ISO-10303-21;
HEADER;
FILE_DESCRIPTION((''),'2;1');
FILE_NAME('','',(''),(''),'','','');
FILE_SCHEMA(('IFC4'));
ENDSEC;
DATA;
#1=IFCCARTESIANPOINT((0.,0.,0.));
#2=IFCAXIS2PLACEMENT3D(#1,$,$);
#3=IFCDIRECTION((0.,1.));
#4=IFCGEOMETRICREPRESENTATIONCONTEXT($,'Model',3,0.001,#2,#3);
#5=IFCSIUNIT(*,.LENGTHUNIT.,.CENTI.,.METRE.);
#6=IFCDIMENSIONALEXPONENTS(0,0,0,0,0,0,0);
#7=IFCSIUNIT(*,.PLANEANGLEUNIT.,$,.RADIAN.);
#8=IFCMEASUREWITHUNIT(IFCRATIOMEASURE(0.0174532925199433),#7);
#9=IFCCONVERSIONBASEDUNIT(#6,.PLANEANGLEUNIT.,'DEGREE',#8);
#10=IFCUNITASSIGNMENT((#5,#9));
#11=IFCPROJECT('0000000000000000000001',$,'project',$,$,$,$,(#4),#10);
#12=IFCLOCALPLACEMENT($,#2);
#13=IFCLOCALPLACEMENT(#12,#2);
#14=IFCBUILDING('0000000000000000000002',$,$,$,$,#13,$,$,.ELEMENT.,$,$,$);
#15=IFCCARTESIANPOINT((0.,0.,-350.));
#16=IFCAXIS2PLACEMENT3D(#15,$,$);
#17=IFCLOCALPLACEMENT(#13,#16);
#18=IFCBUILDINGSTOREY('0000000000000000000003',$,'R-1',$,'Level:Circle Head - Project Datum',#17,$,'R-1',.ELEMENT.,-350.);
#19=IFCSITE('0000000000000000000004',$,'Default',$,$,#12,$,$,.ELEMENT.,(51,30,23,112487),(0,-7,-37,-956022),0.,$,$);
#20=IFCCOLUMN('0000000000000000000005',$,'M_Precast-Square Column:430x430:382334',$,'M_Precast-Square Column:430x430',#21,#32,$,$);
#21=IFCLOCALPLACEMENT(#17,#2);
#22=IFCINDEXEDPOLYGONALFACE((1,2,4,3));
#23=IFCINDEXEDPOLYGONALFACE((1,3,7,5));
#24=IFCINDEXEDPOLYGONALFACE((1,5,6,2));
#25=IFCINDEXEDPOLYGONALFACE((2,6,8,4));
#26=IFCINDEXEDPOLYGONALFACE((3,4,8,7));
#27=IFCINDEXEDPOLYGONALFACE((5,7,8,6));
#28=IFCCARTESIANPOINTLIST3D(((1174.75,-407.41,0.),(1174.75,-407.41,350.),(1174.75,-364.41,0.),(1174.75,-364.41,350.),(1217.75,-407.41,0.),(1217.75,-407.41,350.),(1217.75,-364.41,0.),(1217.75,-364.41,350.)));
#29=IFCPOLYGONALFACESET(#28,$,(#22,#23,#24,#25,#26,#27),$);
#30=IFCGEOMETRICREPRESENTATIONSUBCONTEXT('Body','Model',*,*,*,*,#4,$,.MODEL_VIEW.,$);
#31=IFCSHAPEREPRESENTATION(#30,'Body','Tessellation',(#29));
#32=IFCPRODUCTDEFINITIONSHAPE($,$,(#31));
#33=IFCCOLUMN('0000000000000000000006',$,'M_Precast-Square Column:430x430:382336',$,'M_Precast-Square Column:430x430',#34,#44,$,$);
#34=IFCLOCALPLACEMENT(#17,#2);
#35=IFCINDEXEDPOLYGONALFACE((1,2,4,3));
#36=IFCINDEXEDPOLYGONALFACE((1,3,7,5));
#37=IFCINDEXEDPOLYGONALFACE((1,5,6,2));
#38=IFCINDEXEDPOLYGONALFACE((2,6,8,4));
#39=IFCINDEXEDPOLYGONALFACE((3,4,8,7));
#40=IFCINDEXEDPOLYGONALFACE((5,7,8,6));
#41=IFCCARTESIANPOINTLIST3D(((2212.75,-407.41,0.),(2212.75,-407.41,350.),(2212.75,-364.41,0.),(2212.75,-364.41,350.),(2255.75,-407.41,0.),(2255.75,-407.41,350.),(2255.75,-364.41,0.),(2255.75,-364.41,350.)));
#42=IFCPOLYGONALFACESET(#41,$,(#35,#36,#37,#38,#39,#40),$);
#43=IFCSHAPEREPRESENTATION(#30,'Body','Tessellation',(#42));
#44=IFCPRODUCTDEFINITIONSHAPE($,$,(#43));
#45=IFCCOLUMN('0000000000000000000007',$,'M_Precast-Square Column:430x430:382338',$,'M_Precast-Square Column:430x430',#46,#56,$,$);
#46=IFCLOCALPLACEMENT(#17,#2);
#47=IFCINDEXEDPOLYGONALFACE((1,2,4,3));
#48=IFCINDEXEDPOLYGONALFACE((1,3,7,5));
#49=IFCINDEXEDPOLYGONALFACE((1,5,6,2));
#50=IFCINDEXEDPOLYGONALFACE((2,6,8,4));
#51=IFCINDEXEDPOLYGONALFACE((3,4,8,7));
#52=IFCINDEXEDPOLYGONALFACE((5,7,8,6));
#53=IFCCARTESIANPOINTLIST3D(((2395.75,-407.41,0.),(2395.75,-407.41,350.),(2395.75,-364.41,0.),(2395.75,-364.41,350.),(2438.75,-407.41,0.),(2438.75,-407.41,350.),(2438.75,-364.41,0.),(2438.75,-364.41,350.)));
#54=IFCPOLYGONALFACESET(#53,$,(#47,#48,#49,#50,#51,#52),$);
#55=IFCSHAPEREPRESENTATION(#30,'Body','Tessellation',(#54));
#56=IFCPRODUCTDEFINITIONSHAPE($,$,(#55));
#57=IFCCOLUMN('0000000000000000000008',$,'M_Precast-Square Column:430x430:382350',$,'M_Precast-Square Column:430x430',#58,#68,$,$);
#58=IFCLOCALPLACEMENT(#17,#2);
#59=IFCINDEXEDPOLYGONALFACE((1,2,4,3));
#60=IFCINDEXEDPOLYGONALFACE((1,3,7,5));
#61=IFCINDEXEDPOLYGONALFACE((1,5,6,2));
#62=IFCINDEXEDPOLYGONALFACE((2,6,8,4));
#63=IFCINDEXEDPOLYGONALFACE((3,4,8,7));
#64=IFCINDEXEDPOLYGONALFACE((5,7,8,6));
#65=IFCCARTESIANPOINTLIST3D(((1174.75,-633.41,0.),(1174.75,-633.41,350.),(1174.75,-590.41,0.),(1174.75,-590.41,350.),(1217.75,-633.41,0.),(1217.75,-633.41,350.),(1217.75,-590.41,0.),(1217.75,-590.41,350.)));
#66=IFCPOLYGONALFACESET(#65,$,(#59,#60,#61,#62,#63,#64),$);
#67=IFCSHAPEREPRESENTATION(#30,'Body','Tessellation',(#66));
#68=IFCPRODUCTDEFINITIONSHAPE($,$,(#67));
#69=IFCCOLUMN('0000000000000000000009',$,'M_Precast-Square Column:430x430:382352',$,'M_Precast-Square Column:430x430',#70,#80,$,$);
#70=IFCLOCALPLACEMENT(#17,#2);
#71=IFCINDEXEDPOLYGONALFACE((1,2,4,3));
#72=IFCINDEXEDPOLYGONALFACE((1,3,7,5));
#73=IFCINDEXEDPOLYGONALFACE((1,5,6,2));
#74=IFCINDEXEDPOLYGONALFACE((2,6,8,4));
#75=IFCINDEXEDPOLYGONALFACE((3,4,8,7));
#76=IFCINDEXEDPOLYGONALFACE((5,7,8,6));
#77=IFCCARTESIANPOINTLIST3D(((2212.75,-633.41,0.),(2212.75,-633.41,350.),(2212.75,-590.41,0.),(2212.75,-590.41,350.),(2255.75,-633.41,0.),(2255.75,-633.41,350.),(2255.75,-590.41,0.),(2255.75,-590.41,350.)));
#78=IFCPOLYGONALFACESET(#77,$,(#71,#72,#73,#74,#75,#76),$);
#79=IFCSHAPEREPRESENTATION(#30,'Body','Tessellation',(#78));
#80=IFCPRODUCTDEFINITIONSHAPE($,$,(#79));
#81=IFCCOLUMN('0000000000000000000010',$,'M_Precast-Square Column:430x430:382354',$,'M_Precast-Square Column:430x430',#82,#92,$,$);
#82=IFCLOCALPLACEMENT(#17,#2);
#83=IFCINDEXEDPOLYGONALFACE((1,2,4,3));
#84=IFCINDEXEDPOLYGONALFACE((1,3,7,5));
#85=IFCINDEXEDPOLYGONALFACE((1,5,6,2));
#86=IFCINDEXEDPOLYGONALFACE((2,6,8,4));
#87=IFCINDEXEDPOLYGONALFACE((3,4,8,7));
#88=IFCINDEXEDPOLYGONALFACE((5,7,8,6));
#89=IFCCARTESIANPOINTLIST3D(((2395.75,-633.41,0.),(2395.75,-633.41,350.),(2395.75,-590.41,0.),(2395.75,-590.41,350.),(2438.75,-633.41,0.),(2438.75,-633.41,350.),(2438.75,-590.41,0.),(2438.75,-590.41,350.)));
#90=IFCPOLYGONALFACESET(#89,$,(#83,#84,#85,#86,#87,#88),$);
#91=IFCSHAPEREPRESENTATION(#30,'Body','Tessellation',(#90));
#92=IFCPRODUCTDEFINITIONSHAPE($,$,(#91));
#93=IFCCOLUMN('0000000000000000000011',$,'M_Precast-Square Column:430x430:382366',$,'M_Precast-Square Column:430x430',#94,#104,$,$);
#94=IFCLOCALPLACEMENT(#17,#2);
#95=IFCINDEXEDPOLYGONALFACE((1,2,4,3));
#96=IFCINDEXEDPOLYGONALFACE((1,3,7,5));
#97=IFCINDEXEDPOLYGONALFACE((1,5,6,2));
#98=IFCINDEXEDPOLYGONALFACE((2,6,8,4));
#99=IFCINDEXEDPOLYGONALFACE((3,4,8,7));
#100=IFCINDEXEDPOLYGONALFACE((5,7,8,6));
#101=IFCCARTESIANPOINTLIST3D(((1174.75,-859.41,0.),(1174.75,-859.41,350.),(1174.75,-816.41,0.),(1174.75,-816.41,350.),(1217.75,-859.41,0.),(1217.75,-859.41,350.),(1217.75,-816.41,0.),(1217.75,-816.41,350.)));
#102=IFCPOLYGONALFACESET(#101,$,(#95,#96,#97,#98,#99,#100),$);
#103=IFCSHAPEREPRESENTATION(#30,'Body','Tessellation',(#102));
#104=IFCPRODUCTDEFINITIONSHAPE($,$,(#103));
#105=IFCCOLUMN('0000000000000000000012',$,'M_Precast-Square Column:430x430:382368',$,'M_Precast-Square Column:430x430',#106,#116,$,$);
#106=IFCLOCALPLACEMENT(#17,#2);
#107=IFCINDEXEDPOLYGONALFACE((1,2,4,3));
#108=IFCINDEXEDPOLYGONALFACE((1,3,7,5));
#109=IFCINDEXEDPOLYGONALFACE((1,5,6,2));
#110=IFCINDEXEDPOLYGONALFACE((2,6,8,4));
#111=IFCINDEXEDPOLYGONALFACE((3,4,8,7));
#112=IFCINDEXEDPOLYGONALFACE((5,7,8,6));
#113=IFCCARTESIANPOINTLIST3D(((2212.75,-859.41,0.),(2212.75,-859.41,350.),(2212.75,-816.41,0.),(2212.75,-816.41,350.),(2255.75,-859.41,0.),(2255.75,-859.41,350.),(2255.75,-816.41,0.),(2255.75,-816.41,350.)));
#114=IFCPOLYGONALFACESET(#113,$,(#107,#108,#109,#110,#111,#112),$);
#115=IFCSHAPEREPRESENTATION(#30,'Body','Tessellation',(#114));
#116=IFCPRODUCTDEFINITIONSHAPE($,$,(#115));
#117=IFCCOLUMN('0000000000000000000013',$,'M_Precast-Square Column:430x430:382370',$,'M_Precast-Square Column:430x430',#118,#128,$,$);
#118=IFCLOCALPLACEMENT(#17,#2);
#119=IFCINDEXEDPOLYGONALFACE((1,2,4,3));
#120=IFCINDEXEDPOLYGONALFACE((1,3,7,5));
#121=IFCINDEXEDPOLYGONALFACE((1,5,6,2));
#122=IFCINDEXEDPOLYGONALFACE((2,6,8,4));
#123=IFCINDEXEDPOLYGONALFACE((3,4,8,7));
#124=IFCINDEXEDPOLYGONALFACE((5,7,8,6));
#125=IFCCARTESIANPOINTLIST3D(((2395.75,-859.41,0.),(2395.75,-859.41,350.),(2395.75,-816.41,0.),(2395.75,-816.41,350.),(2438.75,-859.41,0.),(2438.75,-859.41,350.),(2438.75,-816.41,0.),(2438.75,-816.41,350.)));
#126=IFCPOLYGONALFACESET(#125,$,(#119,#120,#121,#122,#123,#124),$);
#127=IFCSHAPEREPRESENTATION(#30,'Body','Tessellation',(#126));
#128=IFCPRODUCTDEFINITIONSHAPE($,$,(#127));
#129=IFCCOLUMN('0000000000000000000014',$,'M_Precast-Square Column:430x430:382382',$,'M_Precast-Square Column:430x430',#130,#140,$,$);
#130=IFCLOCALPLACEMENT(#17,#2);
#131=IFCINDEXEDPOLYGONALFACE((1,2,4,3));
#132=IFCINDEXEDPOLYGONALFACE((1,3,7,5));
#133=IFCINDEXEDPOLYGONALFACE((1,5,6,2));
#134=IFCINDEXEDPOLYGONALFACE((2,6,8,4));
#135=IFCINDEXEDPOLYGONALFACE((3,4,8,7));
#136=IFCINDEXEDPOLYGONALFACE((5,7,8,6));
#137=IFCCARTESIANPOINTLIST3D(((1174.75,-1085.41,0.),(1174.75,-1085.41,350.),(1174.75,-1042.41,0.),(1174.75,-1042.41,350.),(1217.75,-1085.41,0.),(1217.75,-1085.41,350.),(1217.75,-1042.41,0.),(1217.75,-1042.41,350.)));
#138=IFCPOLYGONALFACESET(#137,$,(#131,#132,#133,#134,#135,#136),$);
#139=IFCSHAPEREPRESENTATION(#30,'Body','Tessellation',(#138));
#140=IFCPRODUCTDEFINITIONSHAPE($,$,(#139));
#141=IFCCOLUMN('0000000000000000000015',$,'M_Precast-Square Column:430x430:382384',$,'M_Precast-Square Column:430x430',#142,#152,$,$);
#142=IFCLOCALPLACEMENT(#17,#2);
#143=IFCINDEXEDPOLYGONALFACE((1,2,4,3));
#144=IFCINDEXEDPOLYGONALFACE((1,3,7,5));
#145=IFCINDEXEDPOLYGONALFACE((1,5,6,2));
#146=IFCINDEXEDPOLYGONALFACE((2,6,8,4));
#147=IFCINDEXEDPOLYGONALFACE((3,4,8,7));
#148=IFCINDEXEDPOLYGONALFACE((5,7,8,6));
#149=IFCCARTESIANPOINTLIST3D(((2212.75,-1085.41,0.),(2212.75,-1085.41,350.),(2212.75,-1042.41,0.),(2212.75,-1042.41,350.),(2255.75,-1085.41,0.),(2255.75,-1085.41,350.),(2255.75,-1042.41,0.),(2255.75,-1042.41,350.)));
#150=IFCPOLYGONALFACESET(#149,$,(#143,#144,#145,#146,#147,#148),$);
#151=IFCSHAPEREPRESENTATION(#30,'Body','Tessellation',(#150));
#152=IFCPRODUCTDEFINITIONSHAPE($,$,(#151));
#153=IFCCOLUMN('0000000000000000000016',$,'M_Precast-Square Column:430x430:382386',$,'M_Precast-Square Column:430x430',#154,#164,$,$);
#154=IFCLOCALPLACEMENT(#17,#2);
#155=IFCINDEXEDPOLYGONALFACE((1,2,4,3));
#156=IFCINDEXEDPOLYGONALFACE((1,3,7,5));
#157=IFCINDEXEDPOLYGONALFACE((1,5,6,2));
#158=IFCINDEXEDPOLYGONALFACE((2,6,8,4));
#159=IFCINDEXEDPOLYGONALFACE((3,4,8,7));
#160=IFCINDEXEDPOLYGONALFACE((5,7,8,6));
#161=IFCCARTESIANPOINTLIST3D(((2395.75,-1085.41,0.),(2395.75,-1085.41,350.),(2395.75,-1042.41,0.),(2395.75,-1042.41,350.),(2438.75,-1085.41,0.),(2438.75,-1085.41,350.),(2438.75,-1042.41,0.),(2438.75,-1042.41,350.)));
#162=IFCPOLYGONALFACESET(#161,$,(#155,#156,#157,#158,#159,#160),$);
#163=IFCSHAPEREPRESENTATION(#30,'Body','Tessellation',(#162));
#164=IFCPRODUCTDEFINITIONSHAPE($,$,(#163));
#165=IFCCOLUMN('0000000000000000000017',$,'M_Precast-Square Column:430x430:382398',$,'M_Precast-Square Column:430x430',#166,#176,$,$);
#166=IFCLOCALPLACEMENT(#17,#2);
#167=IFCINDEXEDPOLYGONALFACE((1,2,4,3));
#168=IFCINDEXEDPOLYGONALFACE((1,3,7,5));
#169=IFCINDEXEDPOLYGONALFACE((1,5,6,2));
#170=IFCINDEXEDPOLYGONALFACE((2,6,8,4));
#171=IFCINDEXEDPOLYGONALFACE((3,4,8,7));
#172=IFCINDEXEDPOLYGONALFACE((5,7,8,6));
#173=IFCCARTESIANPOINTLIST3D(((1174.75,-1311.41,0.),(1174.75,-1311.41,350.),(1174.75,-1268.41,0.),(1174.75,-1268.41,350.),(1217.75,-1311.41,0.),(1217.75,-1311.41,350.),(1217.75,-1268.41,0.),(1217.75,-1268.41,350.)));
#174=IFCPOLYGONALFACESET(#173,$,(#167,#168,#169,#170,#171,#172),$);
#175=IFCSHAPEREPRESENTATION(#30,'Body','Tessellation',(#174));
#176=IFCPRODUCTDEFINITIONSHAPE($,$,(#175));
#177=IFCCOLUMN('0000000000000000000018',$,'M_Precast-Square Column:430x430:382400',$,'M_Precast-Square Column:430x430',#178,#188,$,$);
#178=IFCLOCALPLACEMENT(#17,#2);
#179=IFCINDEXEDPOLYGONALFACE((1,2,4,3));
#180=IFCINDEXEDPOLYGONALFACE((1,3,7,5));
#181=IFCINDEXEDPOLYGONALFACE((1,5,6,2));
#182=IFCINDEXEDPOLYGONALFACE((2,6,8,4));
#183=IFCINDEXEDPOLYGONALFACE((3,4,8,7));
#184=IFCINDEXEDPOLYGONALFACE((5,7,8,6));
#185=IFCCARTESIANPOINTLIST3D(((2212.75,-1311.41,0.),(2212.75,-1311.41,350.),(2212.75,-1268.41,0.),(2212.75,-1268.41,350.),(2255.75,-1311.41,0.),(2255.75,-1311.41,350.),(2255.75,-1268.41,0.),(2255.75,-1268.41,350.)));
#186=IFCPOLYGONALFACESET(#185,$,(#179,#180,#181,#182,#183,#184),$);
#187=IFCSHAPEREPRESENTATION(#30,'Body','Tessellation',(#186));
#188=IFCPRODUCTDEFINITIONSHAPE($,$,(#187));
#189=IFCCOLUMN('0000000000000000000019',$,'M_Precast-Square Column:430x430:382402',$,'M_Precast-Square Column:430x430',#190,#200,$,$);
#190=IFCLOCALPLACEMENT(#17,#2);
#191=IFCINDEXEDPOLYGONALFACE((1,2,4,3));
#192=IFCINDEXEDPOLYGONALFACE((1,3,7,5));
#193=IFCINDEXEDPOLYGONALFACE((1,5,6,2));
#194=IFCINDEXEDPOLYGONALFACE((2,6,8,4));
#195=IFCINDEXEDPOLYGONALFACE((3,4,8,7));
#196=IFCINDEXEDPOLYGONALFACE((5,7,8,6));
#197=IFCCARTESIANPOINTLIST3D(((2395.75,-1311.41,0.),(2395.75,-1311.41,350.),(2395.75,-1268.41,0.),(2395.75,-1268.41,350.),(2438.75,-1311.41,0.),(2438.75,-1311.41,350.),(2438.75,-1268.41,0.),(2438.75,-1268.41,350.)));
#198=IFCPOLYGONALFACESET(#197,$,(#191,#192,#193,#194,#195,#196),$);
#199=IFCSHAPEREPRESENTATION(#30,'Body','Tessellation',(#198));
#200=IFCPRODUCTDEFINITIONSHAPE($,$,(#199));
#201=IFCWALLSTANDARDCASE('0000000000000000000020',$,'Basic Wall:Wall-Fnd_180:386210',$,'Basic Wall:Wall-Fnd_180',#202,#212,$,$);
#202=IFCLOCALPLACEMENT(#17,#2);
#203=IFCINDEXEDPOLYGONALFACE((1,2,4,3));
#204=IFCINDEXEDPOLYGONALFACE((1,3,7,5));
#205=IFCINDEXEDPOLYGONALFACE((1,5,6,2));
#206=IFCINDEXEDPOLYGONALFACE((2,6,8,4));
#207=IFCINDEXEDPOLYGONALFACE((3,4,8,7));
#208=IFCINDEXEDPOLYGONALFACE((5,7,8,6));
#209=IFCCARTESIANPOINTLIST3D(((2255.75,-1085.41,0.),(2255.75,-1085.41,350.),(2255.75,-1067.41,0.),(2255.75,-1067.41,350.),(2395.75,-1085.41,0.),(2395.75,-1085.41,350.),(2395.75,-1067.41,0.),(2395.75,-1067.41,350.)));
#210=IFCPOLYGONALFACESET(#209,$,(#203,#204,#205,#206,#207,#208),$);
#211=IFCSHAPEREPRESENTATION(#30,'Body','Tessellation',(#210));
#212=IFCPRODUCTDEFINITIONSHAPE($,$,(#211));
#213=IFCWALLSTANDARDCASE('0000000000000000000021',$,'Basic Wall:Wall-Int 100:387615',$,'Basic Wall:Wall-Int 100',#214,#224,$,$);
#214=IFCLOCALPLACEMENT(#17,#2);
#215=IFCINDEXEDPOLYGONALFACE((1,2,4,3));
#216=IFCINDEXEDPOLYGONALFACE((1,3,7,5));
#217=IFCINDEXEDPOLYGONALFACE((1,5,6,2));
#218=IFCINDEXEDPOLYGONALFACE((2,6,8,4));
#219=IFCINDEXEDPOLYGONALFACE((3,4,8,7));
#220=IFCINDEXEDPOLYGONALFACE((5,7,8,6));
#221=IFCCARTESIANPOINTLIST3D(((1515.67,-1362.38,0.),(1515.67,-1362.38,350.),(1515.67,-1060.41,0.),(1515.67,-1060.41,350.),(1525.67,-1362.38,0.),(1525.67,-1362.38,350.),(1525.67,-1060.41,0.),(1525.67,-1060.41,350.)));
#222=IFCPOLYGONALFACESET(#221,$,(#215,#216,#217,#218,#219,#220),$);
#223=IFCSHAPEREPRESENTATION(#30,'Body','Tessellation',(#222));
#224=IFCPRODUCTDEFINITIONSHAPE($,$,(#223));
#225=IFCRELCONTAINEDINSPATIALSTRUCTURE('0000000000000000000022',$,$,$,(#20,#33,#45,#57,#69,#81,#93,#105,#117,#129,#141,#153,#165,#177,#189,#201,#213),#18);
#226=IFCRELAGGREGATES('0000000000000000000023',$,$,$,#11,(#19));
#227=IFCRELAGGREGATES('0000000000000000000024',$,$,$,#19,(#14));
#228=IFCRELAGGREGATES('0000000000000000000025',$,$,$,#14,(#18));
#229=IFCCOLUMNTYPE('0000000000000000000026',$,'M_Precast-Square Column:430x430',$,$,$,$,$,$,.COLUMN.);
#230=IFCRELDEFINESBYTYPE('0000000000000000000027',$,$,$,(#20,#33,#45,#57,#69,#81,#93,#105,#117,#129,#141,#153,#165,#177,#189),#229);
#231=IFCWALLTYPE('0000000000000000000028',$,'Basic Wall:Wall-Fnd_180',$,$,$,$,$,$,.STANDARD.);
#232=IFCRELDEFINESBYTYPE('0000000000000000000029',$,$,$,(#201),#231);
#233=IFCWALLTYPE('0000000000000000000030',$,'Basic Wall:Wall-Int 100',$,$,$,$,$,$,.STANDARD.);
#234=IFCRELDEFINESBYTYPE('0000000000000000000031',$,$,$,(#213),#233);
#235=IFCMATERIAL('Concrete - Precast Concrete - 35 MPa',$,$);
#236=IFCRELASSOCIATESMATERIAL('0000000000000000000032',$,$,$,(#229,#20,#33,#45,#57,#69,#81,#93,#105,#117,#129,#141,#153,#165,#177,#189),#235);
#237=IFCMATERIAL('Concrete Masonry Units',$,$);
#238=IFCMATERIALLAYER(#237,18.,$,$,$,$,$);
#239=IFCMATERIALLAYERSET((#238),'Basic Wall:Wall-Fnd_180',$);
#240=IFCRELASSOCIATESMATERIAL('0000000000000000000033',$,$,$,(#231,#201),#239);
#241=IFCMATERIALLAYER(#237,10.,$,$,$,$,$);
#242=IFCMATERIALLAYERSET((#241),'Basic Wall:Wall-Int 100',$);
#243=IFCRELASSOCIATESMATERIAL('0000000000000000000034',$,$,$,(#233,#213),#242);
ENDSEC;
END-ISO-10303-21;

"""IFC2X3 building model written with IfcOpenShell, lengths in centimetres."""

from ifc_helpers import new_model, entity, si_unit, converted_unit, direction, frame, frame_2d, origin, origin_2d_with_axis, place, context, subcontext, project, spatial, rectangle, extrude, source, transform, mapped, material, layer, layer_set, layer_usage, type_object, type_shapes, element, save


model = new_model("IFC2X3")

# Units and contexts
model_context = context("Model", 3, precision=0.001, world=origin(), true_north=direction((0.0, 1.0)))
body_context = subcontext(model_context, "Body", "Model", "MODEL_VIEW")
ifc_project = project(units=[si_unit("LENGTHUNIT", "METRE", prefix="CENTI"), converted_unit("PLANEANGLEUNIT", "DEGREE", entity("IfcRatioMeasure", 0.0174532925199433), si_unit("PLANEANGLEUNIT", "RADIAN"), dimensions=[0, 0, 0, 0, 0, 0, 0])], contexts=[model_context])

# Site, building, storey
site_placement = place(None, origin())
site = spatial("IfcSite", under=ifc_project, at=site_placement, Name="Default", CompositionType="ELEMENT", RefLatitude=(51, 30, 23, 112487), RefLongitude=(0, -7, -37, -956022), RefElevation=0.0)
building_placement = place(site_placement, origin())
building = spatial("IfcBuilding", under=site, at=building_placement, CompositionType="ELEMENT")
storey_placement = place(building_placement, frame((0.0, 0.0, -350.0)))
storey = spatial("IfcBuildingStorey", under=building, at=storey_placement, Name="R-1", ObjectType="Level:Circle Head - Project Datum", LongName="R-1", CompositionType="ELEMENT", Elevation=-350.0)

# Columns
ifc_material_1 = material(Name="Concrete - Precast Concrete - 35 MPa")
column_type = type_object("IfcColumnType", Name="M_Precast-Square Column:430x430", PredefinedType="COLUMN", material=ifc_material_1)
shared_shape = source(origin(), body_context, "Body", "SweptSolid", [
    extrude(rectangle(XDim=43.0, YDim=43.0, at=origin_2d_with_axis()), frame((0.0, 0.0, -350.0), z_axis=(0.0, 0.0, 1.0), x_axis=(0.0, -1.0, 0.0)), (0.0, 0.0, 1.0), 350.0),
])
type_shapes(column_type, [shared_shape])
for number, where, z_axis, x_axis, name in (
    (1, (1196.25, -385.91, 350.0), (0.0, 0.0, 1.0), (-1.0, 0.0, 0.0), "M_Precast-Square Column:430x430:382334"),
    (2, (2234.25, -385.91, 350.0), (0.0, 0.0, 1.0), (-1.0, 0.0, 0.0), "M_Precast-Square Column:430x430:382336"),
    (3, (2417.25, -385.91, 350.0), (0.0, 0.0, 1.0), (-1.0, 0.0, 0.0), "M_Precast-Square Column:430x430:382338"),
    (4, (1196.25, -611.91, 350.0), (0.0, 0.0, 1.0), (-1.0, 0.0, 0.0), "M_Precast-Square Column:430x430:382350"),
    (5, (2234.25, -611.91, 350.0), (0.0, 0.0, 1.0), (-1.0, 0.0, 0.0), "M_Precast-Square Column:430x430:382352"),
    (6, (2417.25, -611.91, 350.0), (0.0, 0.0, 1.0), (-1.0, 0.0, 0.0), "M_Precast-Square Column:430x430:382354"),
    (7, (1196.25, -837.91, 350.0), (0.0, 0.0, 1.0), (-1.0, 0.0, 0.0), "M_Precast-Square Column:430x430:382366"),
    (8, (2234.25, -837.91, 350.0), (0.0, 0.0, 1.0), (-1.0, 0.0, 0.0), "M_Precast-Square Column:430x430:382368"),
    (9, (2417.25, -837.91, 350.0), (0.0, 0.0, 1.0), (-1.0, 0.0, 0.0), "M_Precast-Square Column:430x430:382370"),
    (10, (1196.25, -1063.91, 350.0), (0.0, 0.0, 1.0), (-1.0, 0.0, 0.0), "M_Precast-Square Column:430x430:382382"),
    (11, (2234.25, -1063.91, 350.0), (0.0, 0.0, 1.0), (-1.0, 0.0, 0.0), "M_Precast-Square Column:430x430:382384"),
    (12, (2417.25, -1063.91, 350.0), (0.0, 0.0, 1.0), (-1.0, 0.0, 0.0), "M_Precast-Square Column:430x430:382386"),
    (13, (1196.25, -1289.91, 350.0), (0.0, 0.0, 1.0), (-1.0, 0.0, 0.0), "M_Precast-Square Column:430x430:382398"),
    (14, (2234.25, -1289.91, 350.0), (0.0, 0.0, 1.0), (-1.0, 0.0, 0.0), "M_Precast-Square Column:430x430:382400"),
    (15, (2417.25, -1289.91, 350.0), (0.0, 0.0, 1.0), (-1.0, 0.0, 0.0), "M_Precast-Square Column:430x430:382402"),
):
    element("IfcColumn", number, at=place(storey_placement, frame(where, z_axis=z_axis, x_axis=x_axis)), inside=storey, type_object=column_type, material=ifc_material_1, Name=name, ObjectType="M_Precast-Square Column:430x430", context=body_context, shape_type="MappedRepresentation", body=[
        mapped(shared_shape, transform((0.0, 0.0, 0.0), scale=1.0)),
    ])

# Walls
ifc_material_2 = material(Name="Concrete Masonry Units")
ifc_layer_1 = layer(ifc_material_2, 18.0)
ifc_layer_set_1 = layer_set([ifc_layer_1], Name="Basic Wall:Wall-Fnd_180")
ifc_layer_usage_1 = layer_usage(ifc_layer_set_1, "AXIS2", "POSITIVE", -9.0)
wall_type_1 = type_object("IfcWallType", Name="Basic Wall:Wall-Fnd_180", PredefinedType="STANDARD", material=ifc_layer_set_1)
wall_1_placement = place(storey_placement, frame((2255.75, -1076.41, 0.0)))
element("IfcWallStandardCase", 16, at=wall_1_placement, inside=storey, type_object=wall_type_1, material=ifc_layer_usage_1, Name="Basic Wall:Wall-Fnd_180:386210", ObjectType="Basic Wall:Wall-Fnd_180", context=body_context, shape_type="SweptSolid", body=[
    extrude(rectangle(XDim=140.0, YDim=18.0, at=frame_2d((70.0, 0.0), x_axis=(-1.0, 0.0))), origin(), (0.0, 0.0, 1.0), 350.0),
])
ifc_layer_2 = layer(ifc_material_2, 10.0)
ifc_layer_set_2 = layer_set([ifc_layer_2], Name="Basic Wall:Wall-Int 100")
ifc_layer_usage_2 = layer_usage(ifc_layer_set_2, "AXIS2", "NEGATIVE", 5.0)
wall_type_2 = type_object("IfcWallType", Name="Basic Wall:Wall-Int 100", PredefinedType="STANDARD", material=ifc_layer_set_2)
wall_2_placement = place(storey_placement, frame((1520.67, -1362.38, 0.0), z_axis=(0.0, 0.0, 1.0), x_axis=(0.0, 1.0, 0.0)))
element("IfcWallStandardCase", 17, at=wall_2_placement, inside=storey, type_object=wall_type_2, material=ifc_layer_usage_2, Name="Basic Wall:Wall-Int 100:387615", ObjectType="Basic Wall:Wall-Int 100", context=body_context, shape_type="SweptSolid", body=[
    extrude(rectangle(XDim=301.97, YDim=10.0, at=frame_2d((150.98, 0.0), x_axis=(-1.0, 0.0))), origin(), (0.0, 0.0, 1.0), 350.0),
])

save(model, "model.ifc")
